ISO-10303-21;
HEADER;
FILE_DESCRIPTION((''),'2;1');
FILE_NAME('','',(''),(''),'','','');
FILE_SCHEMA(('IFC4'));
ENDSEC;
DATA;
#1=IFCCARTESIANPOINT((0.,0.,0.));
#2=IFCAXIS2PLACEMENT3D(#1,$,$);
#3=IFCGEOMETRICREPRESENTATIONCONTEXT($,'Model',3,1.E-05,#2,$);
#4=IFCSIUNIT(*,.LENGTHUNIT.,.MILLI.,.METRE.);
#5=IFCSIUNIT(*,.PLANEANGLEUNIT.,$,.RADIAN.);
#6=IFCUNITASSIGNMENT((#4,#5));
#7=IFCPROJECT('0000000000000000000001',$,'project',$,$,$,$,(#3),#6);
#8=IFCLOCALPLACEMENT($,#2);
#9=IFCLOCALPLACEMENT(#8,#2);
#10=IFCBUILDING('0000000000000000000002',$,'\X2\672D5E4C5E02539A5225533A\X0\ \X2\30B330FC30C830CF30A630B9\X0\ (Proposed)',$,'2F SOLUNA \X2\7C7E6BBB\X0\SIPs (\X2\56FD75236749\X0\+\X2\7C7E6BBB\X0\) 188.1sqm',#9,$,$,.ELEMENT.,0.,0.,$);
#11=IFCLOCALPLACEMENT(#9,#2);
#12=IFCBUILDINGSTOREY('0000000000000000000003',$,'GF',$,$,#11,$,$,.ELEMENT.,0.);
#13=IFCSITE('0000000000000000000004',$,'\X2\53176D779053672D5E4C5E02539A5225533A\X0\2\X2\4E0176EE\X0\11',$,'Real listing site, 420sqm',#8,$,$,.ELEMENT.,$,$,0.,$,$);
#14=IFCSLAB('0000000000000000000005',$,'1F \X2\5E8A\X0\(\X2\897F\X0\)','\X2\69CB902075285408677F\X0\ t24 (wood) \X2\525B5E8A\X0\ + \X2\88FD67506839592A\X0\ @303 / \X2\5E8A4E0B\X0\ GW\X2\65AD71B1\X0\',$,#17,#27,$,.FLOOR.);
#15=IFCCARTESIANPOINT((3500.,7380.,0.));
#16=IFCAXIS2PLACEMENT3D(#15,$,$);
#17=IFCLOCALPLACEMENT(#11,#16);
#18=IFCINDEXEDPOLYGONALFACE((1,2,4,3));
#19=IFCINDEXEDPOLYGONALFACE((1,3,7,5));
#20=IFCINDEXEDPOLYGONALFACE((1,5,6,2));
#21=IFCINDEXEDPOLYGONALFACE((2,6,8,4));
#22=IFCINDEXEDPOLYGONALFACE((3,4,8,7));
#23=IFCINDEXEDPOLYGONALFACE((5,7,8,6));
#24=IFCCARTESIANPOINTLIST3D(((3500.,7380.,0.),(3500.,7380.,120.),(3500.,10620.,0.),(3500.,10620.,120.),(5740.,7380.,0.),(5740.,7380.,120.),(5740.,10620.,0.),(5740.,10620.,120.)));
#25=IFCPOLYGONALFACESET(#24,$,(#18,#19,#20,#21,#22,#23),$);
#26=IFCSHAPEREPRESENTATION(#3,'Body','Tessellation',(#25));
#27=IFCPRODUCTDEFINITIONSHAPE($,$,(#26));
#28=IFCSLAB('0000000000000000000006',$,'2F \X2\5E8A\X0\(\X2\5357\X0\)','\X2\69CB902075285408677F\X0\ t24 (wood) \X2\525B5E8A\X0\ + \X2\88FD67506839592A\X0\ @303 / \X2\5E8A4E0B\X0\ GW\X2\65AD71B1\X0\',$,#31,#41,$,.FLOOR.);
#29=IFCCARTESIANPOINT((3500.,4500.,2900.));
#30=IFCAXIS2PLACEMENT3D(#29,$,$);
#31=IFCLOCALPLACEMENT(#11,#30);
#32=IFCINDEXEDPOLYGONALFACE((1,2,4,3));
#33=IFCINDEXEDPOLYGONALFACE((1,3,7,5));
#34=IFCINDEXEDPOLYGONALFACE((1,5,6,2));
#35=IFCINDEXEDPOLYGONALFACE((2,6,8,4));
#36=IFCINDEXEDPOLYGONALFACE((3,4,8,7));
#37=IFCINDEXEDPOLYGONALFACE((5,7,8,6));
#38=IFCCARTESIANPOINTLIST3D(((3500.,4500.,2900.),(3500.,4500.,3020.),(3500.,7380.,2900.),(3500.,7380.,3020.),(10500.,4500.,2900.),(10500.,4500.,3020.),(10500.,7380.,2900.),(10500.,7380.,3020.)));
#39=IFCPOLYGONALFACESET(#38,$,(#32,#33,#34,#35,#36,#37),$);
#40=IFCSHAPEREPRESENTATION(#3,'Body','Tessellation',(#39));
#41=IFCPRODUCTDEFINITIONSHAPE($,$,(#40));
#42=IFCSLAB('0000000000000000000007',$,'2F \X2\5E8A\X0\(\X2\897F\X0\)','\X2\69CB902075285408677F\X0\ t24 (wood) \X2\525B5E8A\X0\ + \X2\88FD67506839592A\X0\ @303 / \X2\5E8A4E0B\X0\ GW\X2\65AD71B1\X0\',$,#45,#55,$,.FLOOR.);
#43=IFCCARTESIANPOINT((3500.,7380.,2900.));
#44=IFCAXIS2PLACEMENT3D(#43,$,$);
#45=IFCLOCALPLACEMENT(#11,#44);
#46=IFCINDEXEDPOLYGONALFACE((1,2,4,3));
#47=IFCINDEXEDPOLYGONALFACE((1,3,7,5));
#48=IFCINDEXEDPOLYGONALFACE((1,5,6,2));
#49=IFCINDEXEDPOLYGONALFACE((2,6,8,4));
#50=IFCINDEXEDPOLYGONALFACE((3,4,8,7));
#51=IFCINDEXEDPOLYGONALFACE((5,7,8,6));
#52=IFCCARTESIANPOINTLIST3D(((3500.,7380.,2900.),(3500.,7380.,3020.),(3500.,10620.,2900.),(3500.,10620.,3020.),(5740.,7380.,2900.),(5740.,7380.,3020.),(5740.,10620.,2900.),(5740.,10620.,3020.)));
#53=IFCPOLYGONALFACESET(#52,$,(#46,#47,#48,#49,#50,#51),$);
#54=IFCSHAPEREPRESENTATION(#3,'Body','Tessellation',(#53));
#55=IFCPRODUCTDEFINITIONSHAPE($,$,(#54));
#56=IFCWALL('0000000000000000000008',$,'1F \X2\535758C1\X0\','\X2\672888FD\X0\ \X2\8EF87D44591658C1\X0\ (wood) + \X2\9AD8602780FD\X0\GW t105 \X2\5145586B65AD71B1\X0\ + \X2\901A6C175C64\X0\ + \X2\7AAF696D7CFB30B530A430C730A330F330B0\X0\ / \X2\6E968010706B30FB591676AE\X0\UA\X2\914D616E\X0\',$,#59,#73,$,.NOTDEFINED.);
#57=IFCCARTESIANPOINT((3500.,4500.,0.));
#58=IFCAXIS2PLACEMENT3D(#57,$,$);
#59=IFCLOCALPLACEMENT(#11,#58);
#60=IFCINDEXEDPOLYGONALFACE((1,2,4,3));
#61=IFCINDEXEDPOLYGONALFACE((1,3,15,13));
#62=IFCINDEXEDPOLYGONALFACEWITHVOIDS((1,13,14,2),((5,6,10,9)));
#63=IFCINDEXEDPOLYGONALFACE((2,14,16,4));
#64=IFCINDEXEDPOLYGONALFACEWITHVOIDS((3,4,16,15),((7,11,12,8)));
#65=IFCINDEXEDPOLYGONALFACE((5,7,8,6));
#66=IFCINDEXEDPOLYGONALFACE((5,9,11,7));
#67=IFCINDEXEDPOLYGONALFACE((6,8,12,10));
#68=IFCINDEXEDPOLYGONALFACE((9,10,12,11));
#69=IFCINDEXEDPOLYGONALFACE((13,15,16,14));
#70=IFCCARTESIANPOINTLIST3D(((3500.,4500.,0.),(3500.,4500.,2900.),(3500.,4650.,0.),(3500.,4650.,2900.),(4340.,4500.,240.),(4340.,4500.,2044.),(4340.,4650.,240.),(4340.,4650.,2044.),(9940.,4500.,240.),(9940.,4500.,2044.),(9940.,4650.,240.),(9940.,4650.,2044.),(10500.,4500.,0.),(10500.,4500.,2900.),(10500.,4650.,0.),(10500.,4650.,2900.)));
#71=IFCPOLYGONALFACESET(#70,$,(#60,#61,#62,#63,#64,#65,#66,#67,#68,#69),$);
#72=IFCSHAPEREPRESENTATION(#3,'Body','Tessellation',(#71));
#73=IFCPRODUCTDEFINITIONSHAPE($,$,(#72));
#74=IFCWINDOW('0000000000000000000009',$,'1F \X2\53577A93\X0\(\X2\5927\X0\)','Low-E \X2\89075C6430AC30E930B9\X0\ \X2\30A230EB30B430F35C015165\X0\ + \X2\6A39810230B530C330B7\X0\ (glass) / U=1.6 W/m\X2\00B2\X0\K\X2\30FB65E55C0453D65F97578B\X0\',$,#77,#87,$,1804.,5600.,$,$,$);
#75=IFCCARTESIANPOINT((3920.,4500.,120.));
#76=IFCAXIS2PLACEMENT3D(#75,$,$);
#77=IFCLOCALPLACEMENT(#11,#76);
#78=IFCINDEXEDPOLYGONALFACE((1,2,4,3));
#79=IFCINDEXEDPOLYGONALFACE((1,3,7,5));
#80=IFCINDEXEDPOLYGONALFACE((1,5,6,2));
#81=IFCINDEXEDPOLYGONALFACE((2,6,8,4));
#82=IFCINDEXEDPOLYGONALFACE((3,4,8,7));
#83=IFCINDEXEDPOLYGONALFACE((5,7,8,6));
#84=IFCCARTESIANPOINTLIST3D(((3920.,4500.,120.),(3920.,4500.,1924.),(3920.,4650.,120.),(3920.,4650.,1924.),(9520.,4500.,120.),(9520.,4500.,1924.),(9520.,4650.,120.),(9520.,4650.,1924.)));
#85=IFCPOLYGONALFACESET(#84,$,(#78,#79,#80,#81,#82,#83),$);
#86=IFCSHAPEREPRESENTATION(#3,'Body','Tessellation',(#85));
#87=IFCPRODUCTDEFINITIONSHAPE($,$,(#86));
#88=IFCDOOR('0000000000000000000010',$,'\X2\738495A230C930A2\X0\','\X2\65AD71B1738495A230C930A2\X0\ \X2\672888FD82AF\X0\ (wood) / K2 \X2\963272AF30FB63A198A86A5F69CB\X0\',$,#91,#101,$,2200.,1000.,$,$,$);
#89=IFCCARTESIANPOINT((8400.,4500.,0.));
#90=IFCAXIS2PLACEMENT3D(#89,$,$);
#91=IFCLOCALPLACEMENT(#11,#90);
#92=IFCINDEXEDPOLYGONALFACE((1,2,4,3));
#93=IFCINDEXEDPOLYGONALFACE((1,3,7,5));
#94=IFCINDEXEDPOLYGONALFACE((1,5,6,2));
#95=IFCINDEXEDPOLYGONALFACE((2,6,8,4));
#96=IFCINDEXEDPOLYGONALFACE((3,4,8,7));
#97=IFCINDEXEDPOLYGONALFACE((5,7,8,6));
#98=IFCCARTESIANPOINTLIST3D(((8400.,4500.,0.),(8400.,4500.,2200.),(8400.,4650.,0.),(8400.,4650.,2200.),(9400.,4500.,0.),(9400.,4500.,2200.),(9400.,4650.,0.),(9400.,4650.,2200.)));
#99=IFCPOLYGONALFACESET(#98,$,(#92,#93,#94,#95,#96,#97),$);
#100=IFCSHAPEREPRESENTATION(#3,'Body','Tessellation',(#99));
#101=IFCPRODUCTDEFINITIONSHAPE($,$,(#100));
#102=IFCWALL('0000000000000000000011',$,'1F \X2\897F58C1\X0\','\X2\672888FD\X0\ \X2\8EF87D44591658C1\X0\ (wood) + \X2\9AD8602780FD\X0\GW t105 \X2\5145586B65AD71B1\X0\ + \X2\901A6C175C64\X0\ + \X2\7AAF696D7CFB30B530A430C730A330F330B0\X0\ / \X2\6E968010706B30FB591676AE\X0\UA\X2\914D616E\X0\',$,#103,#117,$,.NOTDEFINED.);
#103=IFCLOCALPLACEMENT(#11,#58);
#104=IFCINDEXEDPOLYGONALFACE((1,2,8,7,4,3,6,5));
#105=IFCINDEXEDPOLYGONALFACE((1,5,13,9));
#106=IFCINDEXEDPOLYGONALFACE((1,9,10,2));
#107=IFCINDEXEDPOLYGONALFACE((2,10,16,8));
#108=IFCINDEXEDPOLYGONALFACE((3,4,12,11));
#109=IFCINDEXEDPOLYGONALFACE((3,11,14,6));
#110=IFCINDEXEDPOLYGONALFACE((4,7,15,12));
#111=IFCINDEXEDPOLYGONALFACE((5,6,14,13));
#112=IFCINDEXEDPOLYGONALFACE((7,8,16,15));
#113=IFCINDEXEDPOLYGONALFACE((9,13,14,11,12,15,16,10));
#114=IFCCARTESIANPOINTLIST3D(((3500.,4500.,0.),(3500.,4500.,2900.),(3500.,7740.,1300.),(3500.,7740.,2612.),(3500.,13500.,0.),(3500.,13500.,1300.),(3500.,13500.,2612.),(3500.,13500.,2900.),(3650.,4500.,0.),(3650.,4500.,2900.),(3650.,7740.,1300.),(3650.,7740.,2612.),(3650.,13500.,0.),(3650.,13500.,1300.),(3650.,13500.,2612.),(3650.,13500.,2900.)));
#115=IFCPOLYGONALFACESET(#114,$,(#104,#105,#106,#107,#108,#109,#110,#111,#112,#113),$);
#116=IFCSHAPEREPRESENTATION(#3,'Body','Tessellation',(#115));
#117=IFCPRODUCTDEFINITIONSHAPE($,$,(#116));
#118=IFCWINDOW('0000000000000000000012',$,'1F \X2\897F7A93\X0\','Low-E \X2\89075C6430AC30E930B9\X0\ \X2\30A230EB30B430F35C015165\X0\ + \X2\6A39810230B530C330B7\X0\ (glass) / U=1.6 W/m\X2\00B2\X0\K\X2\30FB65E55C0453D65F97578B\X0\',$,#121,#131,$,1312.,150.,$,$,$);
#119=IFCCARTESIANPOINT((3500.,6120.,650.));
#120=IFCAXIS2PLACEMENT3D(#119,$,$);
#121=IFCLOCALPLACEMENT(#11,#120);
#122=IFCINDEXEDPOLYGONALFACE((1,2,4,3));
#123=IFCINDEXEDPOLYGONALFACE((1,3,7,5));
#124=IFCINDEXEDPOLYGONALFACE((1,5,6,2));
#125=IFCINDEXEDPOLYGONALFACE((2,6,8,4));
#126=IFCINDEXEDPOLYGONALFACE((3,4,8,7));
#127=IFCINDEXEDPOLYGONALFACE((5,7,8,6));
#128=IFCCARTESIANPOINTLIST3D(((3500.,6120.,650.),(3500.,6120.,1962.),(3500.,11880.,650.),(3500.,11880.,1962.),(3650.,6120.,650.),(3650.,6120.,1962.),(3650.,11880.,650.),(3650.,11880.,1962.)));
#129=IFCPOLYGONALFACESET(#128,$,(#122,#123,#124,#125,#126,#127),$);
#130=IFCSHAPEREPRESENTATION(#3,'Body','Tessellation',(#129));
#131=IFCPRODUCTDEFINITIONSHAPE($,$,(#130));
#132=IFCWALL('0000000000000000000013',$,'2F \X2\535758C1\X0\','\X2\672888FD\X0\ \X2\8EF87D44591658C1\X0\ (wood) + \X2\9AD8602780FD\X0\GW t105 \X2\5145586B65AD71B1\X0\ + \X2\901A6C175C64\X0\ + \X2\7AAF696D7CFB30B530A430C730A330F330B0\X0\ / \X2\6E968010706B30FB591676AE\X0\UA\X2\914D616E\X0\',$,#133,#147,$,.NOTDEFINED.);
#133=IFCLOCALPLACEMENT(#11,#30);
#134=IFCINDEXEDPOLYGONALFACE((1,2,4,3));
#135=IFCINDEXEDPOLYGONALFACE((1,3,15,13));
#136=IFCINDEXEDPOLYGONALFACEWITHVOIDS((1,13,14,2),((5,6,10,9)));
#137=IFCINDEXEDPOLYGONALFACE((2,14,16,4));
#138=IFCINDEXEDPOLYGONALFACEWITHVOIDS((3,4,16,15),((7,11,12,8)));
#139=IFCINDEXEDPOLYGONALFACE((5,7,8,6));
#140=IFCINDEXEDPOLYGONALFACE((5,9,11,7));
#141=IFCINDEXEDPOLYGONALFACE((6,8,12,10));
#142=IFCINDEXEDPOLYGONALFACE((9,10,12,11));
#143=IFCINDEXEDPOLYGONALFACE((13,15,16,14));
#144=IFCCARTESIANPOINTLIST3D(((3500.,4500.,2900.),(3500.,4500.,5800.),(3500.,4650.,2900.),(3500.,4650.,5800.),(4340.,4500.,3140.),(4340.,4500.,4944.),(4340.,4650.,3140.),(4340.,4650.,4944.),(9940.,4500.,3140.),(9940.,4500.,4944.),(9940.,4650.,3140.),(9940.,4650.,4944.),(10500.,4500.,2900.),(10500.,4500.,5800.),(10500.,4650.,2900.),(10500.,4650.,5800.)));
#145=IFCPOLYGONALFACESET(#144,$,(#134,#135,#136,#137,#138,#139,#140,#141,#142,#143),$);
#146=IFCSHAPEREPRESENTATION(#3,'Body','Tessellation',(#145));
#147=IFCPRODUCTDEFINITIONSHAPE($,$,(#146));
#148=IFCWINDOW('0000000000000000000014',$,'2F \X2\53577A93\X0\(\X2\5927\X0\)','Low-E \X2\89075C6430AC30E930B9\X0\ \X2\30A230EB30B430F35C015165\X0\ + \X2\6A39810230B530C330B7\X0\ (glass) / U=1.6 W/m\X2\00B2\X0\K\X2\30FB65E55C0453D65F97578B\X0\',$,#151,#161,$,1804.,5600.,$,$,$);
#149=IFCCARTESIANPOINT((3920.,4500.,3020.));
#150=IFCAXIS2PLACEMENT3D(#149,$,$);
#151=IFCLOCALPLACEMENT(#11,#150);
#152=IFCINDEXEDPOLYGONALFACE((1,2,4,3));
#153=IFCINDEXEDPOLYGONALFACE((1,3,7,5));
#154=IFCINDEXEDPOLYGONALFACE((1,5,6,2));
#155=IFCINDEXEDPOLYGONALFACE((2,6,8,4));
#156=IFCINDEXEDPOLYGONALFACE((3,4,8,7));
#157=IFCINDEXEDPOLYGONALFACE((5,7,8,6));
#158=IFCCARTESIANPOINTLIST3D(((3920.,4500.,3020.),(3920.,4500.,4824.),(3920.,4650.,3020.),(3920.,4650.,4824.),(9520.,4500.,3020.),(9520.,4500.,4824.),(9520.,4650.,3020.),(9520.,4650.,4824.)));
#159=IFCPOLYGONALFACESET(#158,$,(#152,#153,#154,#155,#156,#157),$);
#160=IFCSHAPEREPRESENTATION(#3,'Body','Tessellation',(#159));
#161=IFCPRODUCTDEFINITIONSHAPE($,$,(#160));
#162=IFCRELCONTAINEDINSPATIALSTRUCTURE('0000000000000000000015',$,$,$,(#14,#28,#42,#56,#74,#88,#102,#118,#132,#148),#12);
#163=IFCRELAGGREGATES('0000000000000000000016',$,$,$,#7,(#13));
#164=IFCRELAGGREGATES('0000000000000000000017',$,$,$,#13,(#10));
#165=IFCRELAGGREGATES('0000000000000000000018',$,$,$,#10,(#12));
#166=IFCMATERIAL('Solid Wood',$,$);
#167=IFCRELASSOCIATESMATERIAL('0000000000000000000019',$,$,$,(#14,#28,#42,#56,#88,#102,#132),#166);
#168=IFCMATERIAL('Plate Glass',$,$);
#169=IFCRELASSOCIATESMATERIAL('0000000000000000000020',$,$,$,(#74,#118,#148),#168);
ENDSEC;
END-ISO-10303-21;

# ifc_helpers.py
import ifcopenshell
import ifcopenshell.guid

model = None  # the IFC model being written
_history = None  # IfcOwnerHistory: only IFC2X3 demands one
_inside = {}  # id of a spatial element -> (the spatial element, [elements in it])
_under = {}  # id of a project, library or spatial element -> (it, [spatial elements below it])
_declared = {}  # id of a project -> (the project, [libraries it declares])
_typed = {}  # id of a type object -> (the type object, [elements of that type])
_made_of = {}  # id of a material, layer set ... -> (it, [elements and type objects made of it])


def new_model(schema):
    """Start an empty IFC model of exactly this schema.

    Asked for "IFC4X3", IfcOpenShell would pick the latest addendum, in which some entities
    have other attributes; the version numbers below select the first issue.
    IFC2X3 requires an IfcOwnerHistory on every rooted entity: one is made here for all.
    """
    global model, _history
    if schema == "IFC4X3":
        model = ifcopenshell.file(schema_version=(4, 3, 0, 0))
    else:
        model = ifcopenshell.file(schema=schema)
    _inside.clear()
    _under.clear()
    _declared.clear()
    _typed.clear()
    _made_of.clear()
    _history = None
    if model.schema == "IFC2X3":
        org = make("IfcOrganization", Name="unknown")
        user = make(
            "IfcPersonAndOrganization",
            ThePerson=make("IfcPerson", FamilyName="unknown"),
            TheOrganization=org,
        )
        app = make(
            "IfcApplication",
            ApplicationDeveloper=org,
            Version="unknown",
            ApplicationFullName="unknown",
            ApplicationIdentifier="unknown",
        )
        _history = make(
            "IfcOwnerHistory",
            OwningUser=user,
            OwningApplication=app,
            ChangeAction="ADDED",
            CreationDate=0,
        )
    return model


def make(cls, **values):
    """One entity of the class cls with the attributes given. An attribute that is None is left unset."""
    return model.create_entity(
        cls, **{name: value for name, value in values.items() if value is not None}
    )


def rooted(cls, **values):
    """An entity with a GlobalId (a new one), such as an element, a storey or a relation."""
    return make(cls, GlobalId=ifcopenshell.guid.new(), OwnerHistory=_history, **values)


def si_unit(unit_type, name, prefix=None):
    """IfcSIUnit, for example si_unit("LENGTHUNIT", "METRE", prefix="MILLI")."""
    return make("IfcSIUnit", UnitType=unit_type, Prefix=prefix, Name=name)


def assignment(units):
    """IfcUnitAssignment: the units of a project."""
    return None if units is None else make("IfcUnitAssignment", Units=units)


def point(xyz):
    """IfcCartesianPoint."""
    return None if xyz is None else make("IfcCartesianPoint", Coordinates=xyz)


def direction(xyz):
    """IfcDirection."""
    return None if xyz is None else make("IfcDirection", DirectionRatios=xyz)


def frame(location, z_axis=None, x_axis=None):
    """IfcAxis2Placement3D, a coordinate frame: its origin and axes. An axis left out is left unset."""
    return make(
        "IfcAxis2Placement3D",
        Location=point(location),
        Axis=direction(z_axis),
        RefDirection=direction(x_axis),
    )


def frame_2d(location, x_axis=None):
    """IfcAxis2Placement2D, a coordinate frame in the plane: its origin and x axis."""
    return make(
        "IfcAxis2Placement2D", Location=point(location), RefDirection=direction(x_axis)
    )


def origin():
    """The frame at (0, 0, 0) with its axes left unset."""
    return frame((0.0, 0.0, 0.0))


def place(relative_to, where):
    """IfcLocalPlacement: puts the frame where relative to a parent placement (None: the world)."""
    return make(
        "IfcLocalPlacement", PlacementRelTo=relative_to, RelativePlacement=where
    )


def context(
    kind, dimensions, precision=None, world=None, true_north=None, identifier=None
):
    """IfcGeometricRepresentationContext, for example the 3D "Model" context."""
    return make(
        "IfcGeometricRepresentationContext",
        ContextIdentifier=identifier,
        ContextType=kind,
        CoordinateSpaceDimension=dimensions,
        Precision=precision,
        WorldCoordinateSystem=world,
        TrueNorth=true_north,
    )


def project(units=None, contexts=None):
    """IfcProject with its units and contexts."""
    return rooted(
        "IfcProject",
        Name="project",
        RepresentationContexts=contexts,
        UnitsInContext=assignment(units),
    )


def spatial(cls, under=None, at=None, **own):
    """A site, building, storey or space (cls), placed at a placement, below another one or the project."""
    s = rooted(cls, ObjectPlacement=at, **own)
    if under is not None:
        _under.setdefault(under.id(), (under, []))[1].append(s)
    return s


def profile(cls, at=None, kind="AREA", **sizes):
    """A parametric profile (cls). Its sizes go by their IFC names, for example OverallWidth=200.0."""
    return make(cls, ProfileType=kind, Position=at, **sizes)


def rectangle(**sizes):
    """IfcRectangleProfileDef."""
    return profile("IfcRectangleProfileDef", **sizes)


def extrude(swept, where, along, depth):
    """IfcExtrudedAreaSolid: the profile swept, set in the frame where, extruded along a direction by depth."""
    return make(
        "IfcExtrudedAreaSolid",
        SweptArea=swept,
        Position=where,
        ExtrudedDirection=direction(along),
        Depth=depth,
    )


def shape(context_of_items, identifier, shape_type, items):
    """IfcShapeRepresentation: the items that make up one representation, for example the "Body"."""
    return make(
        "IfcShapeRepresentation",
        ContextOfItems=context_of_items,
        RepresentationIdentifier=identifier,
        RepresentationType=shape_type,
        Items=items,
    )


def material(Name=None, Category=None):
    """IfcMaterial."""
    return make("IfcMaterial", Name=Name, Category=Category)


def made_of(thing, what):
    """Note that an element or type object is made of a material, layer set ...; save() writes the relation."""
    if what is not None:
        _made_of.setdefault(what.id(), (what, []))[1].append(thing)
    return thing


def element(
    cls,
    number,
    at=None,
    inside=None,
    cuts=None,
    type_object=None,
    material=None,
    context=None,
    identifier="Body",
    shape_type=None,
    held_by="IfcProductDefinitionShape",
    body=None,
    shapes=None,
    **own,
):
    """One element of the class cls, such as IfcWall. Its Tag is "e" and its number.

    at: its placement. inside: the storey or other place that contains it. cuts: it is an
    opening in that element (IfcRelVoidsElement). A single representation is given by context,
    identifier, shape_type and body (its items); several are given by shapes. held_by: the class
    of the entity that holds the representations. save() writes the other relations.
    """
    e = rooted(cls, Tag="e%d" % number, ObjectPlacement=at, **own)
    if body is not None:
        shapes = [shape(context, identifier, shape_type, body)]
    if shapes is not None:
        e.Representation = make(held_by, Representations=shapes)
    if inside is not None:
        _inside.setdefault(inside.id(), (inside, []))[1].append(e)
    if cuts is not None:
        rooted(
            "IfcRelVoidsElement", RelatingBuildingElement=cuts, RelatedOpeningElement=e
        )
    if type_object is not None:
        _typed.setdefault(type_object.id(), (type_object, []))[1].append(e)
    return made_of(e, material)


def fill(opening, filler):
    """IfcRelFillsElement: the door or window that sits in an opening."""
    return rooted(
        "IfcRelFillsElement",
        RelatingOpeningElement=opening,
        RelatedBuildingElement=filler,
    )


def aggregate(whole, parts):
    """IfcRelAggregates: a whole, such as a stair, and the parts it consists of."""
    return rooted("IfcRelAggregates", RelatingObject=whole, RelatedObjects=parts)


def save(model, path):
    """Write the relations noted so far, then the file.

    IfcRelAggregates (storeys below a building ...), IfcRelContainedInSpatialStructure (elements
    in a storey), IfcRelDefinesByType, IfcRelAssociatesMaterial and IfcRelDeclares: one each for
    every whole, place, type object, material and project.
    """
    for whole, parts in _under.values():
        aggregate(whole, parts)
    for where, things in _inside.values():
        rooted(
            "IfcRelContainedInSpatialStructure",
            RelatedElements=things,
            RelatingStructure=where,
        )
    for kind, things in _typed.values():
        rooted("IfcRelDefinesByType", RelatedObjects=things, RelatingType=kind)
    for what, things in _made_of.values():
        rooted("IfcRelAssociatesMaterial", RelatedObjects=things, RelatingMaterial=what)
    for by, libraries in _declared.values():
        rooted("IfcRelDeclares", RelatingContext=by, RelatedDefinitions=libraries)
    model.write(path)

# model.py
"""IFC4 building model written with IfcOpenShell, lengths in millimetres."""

from ifc_helpers import new_model, si_unit, frame, frame_2d, origin, place, context, project, spatial, rectangle, extrude, material, element, fill, save


model = new_model("IFC4")

# Units and contexts
model_context = context("Model", 3, precision=1e-05, world=origin())
ifc_project = project(units=[si_unit("LENGTHUNIT", "METRE", prefix="MILLI"), si_unit("PLANEANGLEUNIT", "RADIAN")], contexts=[model_context])

# Site, building, storey
site_placement = place(None, origin())
site = spatial("IfcSite", under=ifc_project, at=site_placement, Name="北海道札幌市厚別区2丁目11", ObjectType="Real listing site, 420sqm", CompositionType="ELEMENT", RefElevation=0.0)
building_placement = place(site_placement, origin())
building = spatial("IfcBuilding", under=site, at=building_placement, Name="札幌市厚別区 コートハウス (Proposed)", ObjectType="2F SOLUNA 籾殻SIPs (国産杉+籾殻) 188.1sqm", CompositionType="ELEMENT", ElevationOfRefHeight=0.0, ElevationOfTerrain=0.0)
storey_placement = place(building_placement, origin())
storey = spatial("IfcBuildingStorey", under=building, at=storey_placement, Name="GF", CompositionType="ELEMENT", Elevation=0.0)

# Slabs
ifc_material_1 = material(Name="Solid Wood")
slab_1_placement = place(storey_placement, frame((3500.0, 7380.0, 0.0)))
element("IfcSlab", 1, at=slab_1_placement, inside=storey, material=ifc_material_1, Name="1F 床(西)", Description="構造用合板 t24 (wood) 剛床 + 製材根太 @303 / 床下 GW断熱", PredefinedType="FLOOR", context=model_context, shape_type="SweptSolid", body=[
    extrude(rectangle(XDim=2240.0, YDim=3240.0, at=frame_2d((1120.0, 1620.0))), frame((3500.0, 7380.0, 0.0)), (0.0, 0.0, 1.0), 120.0),
])
slab_2_placement = place(storey_placement, frame((3500.0, 4500.0, 2900.0)))
element("IfcSlab", 2, at=slab_2_placement, inside=storey, material=ifc_material_1, Name="2F 床(南)", Description="構造用合板 t24 (wood) 剛床 + 製材根太 @303 / 床下 GW断熱", PredefinedType="FLOOR", context=model_context, shape_type="SweptSolid", body=[
    extrude(rectangle(XDim=7000.0, YDim=2880.0, at=frame_2d((3500.0, 1440.0))), frame((3500.0, 4500.0, 2900.0)), (0.0, 0.0, 1.0), 120.0),
])
slab_3_placement = place(storey_placement, frame((3500.0, 7380.0, 2900.0)))
element("IfcSlab", 3, at=slab_3_placement, inside=storey, material=ifc_material_1, Name="2F 床(西)", Description="構造用合板 t24 (wood) 剛床 + 製材根太 @303 / 床下 GW断熱", PredefinedType="FLOOR", context=model_context, shape_type="SweptSolid", body=[
    extrude(rectangle(XDim=2240.0, YDim=3240.0, at=frame_2d((1120.0, 1620.0))), frame((3500.0, 7380.0, 2900.0)), (0.0, 0.0, 1.0), 120.0),
])

# Wall, openings, window, door
wall_1_placement = place(storey_placement, frame((3500.0, 4500.0, 0.0)))
wall_1 = element("IfcWall", 4, at=wall_1_placement, inside=storey, material=ifc_material_1, Name="1F 南壁", Description="木製 軸組外壁 (wood) + 高性能GW t105 充填断熱 + 通気層 + 窯業系サイディング / 準耐火・外皮UA配慮", PredefinedType="NOTDEFINED", context=model_context, shape_type="SweptSolid", body=[
    extrude(rectangle(XDim=7000.0, YDim=150.0, at=frame_2d((3500.0, 75.0))), frame((3500.0, 4500.0, 0.0)), (0.0, 0.0, 1.0), 2900.0),
])
opening_1_placement = place(storey_placement, frame((3920.0, 4500.0, 120.0)))
opening_1 = element("IfcOpeningElement", 5, at=opening_1_placement, cuts=wall_1, PredefinedType="NOTDEFINED", context=model_context, shape_type="SweptSolid", body=[
    extrude(rectangle(XDim=5600.0, YDim=150.0, at=frame_2d((2800.0, 75.0))), frame((3920.0, 4500.0, 120.0)), (0.0, 0.0, 1.0), 1804.0),
])
opening_2_placement = place(storey_placement, frame((8400.0, 4500.0, 0.0)))
opening_2 = element("IfcOpeningElement", 6, at=opening_2_placement, cuts=wall_1, PredefinedType="NOTDEFINED", context=model_context, shape_type="SweptSolid", body=[
    extrude(rectangle(XDim=1000.0, YDim=150.0, at=frame_2d((500.0, 75.0))), frame((8400.0, 4500.0, 0.0)), (0.0, 0.0, 1.0), 2200.0),
])
ifc_material_2 = material(Name="Plate Glass")
window_1_placement = place(storey_placement, frame((3920.0, 4500.0, 120.0)))
window_1 = element("IfcWindow", 7, at=window_1_placement, inside=storey, material=ifc_material_2, Name="1F 南窓(大)", Description="Low-E 複層ガラス アルゴン封入 + 樹脂サッシ (glass) / U=1.6 W/m²K・日射取得型", OverallHeight=1804.0, OverallWidth=5600.0, context=model_context, shape_type="SweptSolid", body=[
    extrude(rectangle(XDim=5600.0, YDim=150.0, at=frame_2d((2800.0, 75.0))), frame((3920.0, 4500.0, 120.0)), (0.0, 0.0, 1.0), 1804.0),
])
fill(opening_1, window_1)
door_placement = place(storey_placement, frame((8400.0, 4500.0, 0.0)))
door = element("IfcDoor", 8, at=door_placement, inside=storey, material=ifc_material_1, Name="玄関ドア", Description="断熱玄関ドア 木製芯 (wood) / K2 防犯・採風機構", OverallHeight=2200.0, OverallWidth=1000.0, context=model_context, shape_type="SweptSolid", body=[
    extrude(rectangle(XDim=1000.0, YDim=150.0, at=frame_2d((500.0, 75.0))), frame((8400.0, 4500.0, 0.0)), (0.0, 0.0, 1.0), 2200.0),
])
fill(opening_2, door)

# Walls, openings, windows
wall_2_placement = place(storey_placement, frame((3500.0, 4500.0, 0.0)))
wall_2 = element("IfcWall", 9, at=wall_2_placement, inside=storey, material=ifc_material_1, Name="1F 西壁", Description="木製 軸組外壁 (wood) + 高性能GW t105 充填断熱 + 通気層 + 窯業系サイディング / 準耐火・外皮UA配慮", PredefinedType="NOTDEFINED", context=model_context, shape_type="SweptSolid", body=[
    extrude(rectangle(XDim=150.0, YDim=9000.0, at=frame_2d((75.0, 4500.0))), frame((3500.0, 4500.0, 0.0)), (0.0, 0.0, 1.0), 2900.0),
])
opening_3_placement = place(storey_placement, frame((3500.0, 6120.0, 650.0)))
opening_3 = element("IfcOpeningElement", 10, at=opening_3_placement, cuts=wall_2, PredefinedType="NOTDEFINED", context=model_context, shape_type="SweptSolid", body=[
    extrude(rectangle(XDim=150.0, YDim=5760.0, at=frame_2d((75.0, 2880.0))), frame((3500.0, 6120.0, 650.0)), (0.0, 0.0, 1.0), 1312.0),
])
window_2_placement = place(storey_placement, frame((3500.0, 6120.0, 650.0)))
window_2 = element("IfcWindow", 11, at=window_2_placement, inside=storey, material=ifc_material_2, Name="1F 西窓", Description="Low-E 複層ガラス アルゴン封入 + 樹脂サッシ (glass) / U=1.6 W/m²K・日射取得型", OverallHeight=1312.0, OverallWidth=150.0, context=model_context, shape_type="SweptSolid", body=[
    extrude(rectangle(XDim=150.0, YDim=5760.0, at=frame_2d((75.0, 2880.0))), frame((3500.0, 6120.0, 650.0)), (0.0, 0.0, 1.0), 1312.0),
])
fill(opening_3, window_2)
wall_3_placement = place(storey_placement, frame((3500.0, 4500.0, 2900.0)))
wall_3 = element("IfcWall", 12, at=wall_3_placement, inside=storey, material=ifc_material_1, Name="2F 南壁", Description="木製 軸組外壁 (wood) + 高性能GW t105 充填断熱 + 通気層 + 窯業系サイディング / 準耐火・外皮UA配慮", PredefinedType="NOTDEFINED", context=model_context, shape_type="SweptSolid", body=[
    extrude(rectangle(XDim=7000.0, YDim=150.0, at=frame_2d((3500.0, 75.0))), frame((3500.0, 4500.0, 2900.0)), (0.0, 0.0, 1.0), 2900.0),
])
opening_4_placement = place(storey_placement, frame((3920.0, 4500.0, 3020.0)))
opening_4 = element("IfcOpeningElement", 13, at=opening_4_placement, cuts=wall_3, PredefinedType="NOTDEFINED", context=model_context, shape_type="SweptSolid", body=[
    extrude(rectangle(XDim=5600.0, YDim=150.0, at=frame_2d((2800.0, 75.0))), frame((3920.0, 4500.0, 3020.0)), (0.0, 0.0, 1.0), 1804.0),
])
window_3_placement = place(storey_placement, frame((3920.0, 4500.0, 3020.0)))
window_3 = element("IfcWindow", 14, at=window_3_placement, inside=storey, material=ifc_material_2, Name="2F 南窓(大)", Description="Low-E 複層ガラス アルゴン封入 + 樹脂サッシ (glass) / U=1.6 W/m²K・日射取得型", OverallHeight=1804.0, OverallWidth=5600.0, context=model_context, shape_type="SweptSolid", body=[
    extrude(rectangle(XDim=5600.0, YDim=150.0, at=frame_2d((2800.0, 75.0))), frame((3920.0, 4500.0, 3020.0)), (0.0, 0.0, 1.0), 1804.0),
])
fill(opening_4, window_3)

save(model, "model.ifc")
